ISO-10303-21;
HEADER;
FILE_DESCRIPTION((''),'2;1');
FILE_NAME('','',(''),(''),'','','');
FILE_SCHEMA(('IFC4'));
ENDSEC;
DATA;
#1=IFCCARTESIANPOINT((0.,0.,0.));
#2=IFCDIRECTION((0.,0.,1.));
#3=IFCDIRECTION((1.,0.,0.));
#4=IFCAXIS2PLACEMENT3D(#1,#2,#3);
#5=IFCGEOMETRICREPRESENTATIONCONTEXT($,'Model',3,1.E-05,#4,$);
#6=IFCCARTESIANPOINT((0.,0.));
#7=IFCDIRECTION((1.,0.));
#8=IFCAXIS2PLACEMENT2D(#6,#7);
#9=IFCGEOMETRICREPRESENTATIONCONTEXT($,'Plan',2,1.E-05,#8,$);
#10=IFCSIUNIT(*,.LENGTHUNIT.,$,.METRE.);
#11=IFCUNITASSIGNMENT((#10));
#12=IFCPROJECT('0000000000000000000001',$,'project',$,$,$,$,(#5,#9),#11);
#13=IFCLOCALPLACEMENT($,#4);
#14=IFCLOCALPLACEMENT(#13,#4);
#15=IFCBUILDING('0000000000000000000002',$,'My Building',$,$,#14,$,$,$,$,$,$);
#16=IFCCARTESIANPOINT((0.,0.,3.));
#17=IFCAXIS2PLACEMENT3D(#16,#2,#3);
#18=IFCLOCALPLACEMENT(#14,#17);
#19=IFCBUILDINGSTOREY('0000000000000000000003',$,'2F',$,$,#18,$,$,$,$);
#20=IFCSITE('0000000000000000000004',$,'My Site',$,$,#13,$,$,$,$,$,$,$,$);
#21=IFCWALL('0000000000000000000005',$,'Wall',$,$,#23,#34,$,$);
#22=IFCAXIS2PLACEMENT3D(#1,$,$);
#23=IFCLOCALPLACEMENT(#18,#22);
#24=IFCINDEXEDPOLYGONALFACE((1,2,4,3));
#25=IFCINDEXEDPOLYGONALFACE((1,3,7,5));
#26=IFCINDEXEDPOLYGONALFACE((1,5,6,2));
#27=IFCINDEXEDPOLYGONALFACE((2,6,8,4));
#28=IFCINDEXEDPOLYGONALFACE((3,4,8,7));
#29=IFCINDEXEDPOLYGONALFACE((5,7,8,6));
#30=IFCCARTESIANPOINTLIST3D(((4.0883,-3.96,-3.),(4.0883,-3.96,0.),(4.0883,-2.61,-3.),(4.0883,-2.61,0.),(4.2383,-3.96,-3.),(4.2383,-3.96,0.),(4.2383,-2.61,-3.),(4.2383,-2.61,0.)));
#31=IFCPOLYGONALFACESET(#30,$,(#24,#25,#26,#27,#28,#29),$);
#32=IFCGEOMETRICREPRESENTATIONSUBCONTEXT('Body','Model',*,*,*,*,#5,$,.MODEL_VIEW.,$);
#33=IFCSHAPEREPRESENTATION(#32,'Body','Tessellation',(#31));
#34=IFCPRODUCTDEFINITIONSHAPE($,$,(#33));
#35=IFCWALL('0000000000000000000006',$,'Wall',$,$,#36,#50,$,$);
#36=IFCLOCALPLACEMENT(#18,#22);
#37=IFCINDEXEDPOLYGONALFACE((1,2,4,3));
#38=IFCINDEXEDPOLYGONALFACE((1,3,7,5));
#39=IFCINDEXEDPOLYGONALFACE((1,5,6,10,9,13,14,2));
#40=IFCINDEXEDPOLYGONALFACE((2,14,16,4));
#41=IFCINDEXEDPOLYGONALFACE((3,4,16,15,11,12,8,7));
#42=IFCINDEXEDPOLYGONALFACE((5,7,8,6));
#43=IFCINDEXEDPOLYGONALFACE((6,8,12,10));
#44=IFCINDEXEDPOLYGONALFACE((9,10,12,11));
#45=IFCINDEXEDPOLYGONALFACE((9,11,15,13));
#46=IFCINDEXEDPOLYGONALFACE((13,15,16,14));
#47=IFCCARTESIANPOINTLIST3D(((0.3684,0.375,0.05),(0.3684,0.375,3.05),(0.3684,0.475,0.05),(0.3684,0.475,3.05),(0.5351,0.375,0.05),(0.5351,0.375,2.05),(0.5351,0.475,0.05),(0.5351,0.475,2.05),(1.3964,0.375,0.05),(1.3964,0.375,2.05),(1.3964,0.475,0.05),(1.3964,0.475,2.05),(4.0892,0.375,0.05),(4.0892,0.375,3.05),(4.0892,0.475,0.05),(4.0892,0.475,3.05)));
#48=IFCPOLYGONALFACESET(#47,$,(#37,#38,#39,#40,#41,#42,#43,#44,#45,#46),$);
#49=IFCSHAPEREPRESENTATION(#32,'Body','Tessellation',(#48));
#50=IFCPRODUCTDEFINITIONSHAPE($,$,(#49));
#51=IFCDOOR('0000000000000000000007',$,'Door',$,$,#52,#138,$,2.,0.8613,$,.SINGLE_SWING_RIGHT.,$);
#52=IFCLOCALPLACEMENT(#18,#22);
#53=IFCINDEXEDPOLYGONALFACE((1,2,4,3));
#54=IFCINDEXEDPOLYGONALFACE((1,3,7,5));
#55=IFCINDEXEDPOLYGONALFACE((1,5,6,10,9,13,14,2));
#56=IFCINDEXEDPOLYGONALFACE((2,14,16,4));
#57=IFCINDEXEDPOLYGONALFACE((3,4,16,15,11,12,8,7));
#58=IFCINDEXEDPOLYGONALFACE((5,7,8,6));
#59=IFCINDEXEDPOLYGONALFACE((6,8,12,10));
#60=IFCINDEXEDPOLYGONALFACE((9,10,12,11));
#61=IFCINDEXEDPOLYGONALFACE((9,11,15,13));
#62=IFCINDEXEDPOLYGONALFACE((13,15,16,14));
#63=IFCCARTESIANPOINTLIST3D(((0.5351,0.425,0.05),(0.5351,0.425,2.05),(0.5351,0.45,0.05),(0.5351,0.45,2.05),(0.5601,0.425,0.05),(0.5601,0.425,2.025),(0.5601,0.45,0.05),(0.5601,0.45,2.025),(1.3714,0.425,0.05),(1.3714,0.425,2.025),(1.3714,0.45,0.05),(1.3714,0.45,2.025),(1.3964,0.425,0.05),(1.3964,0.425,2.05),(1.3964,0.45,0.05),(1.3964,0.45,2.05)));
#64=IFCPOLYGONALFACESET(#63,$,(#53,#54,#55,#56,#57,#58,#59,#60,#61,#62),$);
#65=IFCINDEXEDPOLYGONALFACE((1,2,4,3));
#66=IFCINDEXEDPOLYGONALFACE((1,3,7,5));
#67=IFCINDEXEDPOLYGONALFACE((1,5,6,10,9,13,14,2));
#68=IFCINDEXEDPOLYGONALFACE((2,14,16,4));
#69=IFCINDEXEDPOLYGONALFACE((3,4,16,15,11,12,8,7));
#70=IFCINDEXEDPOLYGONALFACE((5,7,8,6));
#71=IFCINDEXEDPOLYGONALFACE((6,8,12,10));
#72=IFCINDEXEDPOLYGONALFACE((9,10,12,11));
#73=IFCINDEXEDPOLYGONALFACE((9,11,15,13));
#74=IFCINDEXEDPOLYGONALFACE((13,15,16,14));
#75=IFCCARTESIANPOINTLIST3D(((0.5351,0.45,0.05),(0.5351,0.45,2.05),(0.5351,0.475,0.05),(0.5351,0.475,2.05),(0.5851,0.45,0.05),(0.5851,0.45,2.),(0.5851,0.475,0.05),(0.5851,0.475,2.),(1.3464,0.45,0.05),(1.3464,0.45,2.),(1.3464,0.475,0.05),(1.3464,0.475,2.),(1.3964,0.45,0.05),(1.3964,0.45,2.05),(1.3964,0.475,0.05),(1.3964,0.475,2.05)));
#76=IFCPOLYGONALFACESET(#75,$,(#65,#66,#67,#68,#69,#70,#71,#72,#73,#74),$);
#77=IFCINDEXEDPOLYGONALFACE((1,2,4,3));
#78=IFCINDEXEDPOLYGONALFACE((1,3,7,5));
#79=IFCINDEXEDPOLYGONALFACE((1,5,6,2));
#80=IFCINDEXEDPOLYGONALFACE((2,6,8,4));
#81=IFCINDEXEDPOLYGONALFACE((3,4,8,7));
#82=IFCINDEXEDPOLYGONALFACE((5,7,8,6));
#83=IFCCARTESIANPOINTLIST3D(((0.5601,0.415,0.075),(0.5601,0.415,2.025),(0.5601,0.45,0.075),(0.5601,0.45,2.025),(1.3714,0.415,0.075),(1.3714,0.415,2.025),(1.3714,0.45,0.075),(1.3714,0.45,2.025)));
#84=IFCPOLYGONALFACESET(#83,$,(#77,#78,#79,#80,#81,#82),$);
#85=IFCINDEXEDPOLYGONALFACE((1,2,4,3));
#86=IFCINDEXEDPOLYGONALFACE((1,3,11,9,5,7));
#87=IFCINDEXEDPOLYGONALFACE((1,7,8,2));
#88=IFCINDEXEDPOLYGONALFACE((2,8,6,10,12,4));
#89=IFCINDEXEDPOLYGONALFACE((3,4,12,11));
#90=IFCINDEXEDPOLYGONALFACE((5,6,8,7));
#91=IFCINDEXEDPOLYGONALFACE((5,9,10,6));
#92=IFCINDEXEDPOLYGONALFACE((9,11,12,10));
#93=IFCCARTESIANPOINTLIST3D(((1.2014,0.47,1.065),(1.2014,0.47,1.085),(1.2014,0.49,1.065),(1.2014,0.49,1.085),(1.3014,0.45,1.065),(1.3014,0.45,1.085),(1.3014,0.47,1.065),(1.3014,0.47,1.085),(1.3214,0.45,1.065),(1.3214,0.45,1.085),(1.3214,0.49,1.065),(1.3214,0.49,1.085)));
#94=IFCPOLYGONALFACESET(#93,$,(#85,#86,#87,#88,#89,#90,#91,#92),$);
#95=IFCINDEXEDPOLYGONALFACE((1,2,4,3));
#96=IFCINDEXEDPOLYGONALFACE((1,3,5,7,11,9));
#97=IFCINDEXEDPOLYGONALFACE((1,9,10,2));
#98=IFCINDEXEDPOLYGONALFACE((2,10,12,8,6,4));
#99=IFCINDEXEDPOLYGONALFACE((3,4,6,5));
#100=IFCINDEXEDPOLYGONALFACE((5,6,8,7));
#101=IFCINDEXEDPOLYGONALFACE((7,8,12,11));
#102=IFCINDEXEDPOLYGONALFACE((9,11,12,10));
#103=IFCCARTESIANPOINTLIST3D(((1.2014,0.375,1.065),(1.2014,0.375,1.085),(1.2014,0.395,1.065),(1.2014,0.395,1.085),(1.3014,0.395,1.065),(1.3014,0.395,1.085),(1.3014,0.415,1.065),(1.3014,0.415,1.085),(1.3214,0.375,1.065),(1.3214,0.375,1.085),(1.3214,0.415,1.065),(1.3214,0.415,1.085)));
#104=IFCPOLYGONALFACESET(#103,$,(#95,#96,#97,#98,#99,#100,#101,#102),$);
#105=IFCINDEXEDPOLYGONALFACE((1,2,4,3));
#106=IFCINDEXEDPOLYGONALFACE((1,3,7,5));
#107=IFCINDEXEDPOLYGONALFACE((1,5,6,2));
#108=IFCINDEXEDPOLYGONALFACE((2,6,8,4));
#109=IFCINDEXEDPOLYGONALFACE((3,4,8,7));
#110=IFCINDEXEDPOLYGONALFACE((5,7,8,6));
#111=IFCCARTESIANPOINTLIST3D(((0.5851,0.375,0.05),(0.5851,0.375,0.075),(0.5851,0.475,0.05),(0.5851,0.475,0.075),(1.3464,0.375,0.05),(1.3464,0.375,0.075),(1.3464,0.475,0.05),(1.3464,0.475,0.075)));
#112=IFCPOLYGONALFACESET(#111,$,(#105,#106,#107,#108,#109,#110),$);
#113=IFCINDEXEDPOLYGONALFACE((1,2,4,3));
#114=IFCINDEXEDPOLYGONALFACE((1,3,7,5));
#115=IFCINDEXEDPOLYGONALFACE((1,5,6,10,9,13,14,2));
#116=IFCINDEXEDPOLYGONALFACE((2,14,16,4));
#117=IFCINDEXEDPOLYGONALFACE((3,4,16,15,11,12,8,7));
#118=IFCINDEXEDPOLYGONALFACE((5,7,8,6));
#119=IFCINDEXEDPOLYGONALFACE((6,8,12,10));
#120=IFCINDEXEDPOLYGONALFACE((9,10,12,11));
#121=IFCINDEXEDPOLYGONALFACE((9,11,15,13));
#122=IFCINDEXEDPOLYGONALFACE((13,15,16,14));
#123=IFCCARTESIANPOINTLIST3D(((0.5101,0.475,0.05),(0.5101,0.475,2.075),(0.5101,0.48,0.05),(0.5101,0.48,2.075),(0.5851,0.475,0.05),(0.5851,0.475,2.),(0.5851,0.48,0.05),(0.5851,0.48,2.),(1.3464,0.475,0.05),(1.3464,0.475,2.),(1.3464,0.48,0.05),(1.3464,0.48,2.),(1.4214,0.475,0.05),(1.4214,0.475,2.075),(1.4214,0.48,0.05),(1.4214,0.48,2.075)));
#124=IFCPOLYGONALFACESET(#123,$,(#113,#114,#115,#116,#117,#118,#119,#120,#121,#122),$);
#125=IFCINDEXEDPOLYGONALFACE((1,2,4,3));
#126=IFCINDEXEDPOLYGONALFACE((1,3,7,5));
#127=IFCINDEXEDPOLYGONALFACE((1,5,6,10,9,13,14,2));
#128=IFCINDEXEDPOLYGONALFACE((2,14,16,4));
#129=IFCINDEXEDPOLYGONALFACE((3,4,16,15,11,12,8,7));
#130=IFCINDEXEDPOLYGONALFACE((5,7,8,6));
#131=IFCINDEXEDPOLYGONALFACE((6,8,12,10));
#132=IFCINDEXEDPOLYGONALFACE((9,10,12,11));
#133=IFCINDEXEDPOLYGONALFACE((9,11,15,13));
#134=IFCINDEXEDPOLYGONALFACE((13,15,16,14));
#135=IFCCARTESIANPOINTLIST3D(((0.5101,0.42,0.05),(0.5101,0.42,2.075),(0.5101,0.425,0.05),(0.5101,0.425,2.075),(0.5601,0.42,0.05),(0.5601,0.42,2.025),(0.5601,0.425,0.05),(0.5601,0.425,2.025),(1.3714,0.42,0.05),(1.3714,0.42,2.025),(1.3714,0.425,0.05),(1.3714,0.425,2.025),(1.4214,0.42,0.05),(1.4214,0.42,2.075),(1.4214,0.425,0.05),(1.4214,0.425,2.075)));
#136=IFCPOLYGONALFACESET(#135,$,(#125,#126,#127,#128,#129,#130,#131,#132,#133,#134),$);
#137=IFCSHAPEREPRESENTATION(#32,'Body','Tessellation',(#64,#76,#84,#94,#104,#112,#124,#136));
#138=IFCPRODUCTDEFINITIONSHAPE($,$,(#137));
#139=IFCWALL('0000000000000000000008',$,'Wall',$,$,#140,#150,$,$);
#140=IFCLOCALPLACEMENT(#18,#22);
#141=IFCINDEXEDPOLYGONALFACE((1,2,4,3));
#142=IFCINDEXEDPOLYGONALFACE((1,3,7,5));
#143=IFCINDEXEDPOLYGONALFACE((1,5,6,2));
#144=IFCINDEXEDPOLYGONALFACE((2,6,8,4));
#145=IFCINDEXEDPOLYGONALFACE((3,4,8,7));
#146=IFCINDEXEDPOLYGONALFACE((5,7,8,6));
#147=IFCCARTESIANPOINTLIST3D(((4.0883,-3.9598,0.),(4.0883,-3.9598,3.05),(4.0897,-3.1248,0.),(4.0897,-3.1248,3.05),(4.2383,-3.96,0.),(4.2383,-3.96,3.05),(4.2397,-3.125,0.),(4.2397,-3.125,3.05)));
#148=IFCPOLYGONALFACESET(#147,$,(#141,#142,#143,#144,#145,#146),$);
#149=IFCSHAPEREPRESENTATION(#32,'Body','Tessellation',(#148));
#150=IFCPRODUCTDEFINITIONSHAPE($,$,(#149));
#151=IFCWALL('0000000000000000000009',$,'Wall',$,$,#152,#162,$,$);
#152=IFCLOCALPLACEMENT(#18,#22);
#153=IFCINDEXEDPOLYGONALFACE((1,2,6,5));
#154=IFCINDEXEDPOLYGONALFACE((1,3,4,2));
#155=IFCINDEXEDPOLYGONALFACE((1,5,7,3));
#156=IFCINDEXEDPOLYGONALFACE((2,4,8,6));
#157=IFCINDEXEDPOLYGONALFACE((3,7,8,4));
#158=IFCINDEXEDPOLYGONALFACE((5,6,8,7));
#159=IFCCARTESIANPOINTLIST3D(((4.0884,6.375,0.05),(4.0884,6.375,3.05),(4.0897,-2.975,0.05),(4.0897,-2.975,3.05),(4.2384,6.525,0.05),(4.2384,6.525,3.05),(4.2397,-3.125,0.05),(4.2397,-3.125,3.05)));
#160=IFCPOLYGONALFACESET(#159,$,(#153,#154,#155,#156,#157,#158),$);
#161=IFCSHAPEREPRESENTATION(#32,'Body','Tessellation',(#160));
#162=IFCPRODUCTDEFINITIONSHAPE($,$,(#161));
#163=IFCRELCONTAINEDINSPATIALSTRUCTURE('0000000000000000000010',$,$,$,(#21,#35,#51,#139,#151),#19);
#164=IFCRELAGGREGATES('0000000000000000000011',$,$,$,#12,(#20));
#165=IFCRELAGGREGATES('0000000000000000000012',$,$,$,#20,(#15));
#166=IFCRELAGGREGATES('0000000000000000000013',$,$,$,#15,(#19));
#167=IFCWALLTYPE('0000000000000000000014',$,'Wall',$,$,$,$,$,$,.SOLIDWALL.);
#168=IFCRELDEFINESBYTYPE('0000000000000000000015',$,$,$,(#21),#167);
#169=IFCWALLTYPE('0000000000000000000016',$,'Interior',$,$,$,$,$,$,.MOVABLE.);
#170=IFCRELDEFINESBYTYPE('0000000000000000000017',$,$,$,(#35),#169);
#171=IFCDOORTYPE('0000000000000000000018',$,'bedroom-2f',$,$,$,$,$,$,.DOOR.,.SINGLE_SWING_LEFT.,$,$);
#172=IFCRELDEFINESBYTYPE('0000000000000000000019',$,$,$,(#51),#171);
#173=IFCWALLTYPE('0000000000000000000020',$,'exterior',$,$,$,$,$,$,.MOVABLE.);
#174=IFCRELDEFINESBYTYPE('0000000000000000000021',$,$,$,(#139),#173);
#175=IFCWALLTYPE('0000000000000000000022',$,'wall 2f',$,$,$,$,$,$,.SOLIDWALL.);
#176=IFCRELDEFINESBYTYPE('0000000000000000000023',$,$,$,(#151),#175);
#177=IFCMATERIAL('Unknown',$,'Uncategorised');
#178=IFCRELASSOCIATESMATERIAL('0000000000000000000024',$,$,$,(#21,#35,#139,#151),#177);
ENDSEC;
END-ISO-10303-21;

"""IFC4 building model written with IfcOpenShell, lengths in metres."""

from ifc_helpers import new_model, entity, si_unit, frame, origin_with_axes, origin_2d_with_axis, place, context, subcontext, project, spatial, line, indexed_curve, outline, extrude, shape, source, transform, mapped, material, type_object, type_shapes, element, fill, save


model = new_model("IFC4")

# Units and contexts
model_context = context("Model", 3, precision=1e-05, world=origin_with_axes())
plan_context = context("Plan", 2, precision=1e-05, world=origin_2d_with_axis())
body_context_1 = subcontext(model_context, "Body", "Model", "MODEL_VIEW")
body_context_2 = subcontext(plan_context, "Body", "Plan", "PLAN_VIEW")
ifc_project = project(units=[si_unit("LENGTHUNIT", "METRE")], contexts=[model_context, plan_context])

# Site, building, storey
site_placement = place(None, origin_with_axes())
site = spatial("IfcSite", under=ifc_project, at=site_placement, Name="My Site")
building_placement = place(site_placement, origin_with_axes())
building = spatial("IfcBuilding", under=site, at=building_placement, Name="My Building")
storey_placement = place(building_placement, frame((0.0, 0.0, 3.0), z_axis=(0.0, 0.0, 1.0), x_axis=(1.0, 0.0, 0.0)))
storey = spatial("IfcBuildingStorey", under=building, at=storey_placement, Name="2F")

# Wall
ifc_material = material(Name="Unknown", Category="Uncategorised")
wall_type_1 = type_object("IfcWallType", Name="Wall", PredefinedType="SOLIDWALL")
wall_1_placement = place(storey_placement, frame((4.0883, -2.61, -3.0), z_axis=(0.0, 0.0, 1.0), x_axis=(0.0, -1.0, 0.0)))
element("IfcWall", 1, at=wall_1_placement, inside=storey, type_object=wall_type_1, material=ifc_material, Name="Wall", context=body_context_1, shape_type="SweptSolid", body=[
    extrude(outline(indexed_curve([(0.0, 0.0), (0.0, 0.15), (1.35, 0.15), (1.35, 0.0)], segments=[line(1, 2, 3, 4, 1)])), origin_with_axes(), (0.0, 0.0, 1.0), 3.0),
])

# Wall, opening, door
wall_type_2 = type_object("IfcWallType", Name="Interior", PredefinedType="MOVABLE")
wall_2_placement = place(storey_placement, frame((0.3684, 0.375, 0.05), z_axis=(0.0, 0.0, 1.0), x_axis=(1.0, 0.0, 0.0)))
wall_2 = element("IfcWall", 2, at=wall_2_placement, inside=storey, type_object=wall_type_2, material=ifc_material, Name="Wall", context=body_context_1, shape_type="SweptSolid", body=[
    extrude(outline(indexed_curve([(0.0, 0.0), (0.0, 0.1), (3.7209, 0.1), (3.7209, 0.0)], segments=[line(1, 2, 3, 4, 1)])), origin_with_axes(), (0.0, 0.0, 1.0), 3.0),
])
shared_shape_1 = source(origin_with_axes(), body_context_1, "Body", "SweptSolid", [
    extrude(outline(indexed_curve([(0.0, 0.0), (0.8613, 0.0), (0.8613, 2.0), (0.0, 2.0)], segments=[line(1, 2, 3, 4, 1)])), frame((0.0, -0.6, 0.0), z_axis=(0.0, -1.0, 0.0), x_axis=(1.0, 0.0, 0.0)), (0.0, 0.0, -1.0), 1.2),
])
opening_1_placement = place(wall_2_placement, frame((1.028, 0.1, 0.0), z_axis=(0.0, 0.0, 1.0), x_axis=(-1.0, 0.0, 0.0)))
opening_1 = element("IfcOpeningElement", 3, at=opening_1_placement, cuts=wall_2, PredefinedType="OPENING", context=body_context_1, shape_type="MappedRepresentation", body=[
    mapped(shared_shape_1, transform((0.0, 0.0, 0.0), x_axis=(1.0, 0.0, 0.0), y_axis=(0.0, 1.0, 0.0), z_axis=(0.0, 0.0, 1.0), scale=1.0)),
])
door_type_1 = type_object("IfcDoorType", Name="bedroom-2f", OperationType="SINGLE_SWING_LEFT", PredefinedType="DOOR")
shared_shape_2 = source(origin_with_axes(), body_context_1, "Body", "SweptSolid", [
    extrude(outline(indexed_curve([(0.0, 0.0), (0.0, 2.0), (0.8613, 2.0), (0.8613, 0.0), (0.8363, 0.0), (0.8363, 1.975), (0.025, 1.975), (0.025, 0.0)], segments=[line(1, 2, 3, 4, 5, 6, 7, 8, 1)])), frame((0.0, 0.025, 0.0), z_axis=(0.0, -1.0, 0.0), x_axis=(1.0, 0.0, 0.0)), (0.0, 0.0, -1.0), 0.025),
    extrude(outline(indexed_curve([(0.0, 0.0), (0.0, 2.0), (0.8613, 2.0), (0.8613, 0.0), (0.8113, 0.0), (0.8113, 1.95), (0.05, 1.95), (0.05, 0.0)], segments=[line(1, 2, 3, 4, 5, 6, 7, 8, 1)])), frame((0.0, 0.0, 0.0), z_axis=(0.0, -1.0, 0.0), x_axis=(1.0, 0.0, 0.0)), (0.0, 0.0, -1.0), 0.025),
    extrude(outline(indexed_curve([(0.0, 0.0), (0.8113, 0.0), (0.8113, 0.035), (0.0, 0.035)], segments=[line(1, 2, 3, 4, 1)])), frame((0.025, 0.025, 0.025), z_axis=(0.0, 0.0, 1.0), x_axis=(1.0, 0.0, 0.0)), (0.0, 0.0, 1.0), 1.95),
    extrude(outline(indexed_curve([(0.0, 0.0), (0.0, -0.04), (0.12, -0.04), (0.12, -0.02), (0.02, -0.02), (0.02, 0.0)], segments=[line(1, 2, 3, 4, 5, 6, 1)])), frame((0.075, 0.025, 1.015), z_axis=(0.0, 0.0, 1.0), x_axis=(1.0, 0.0, 0.0)), (0.0, 0.0, 1.0), 0.02),
    extrude(outline(indexed_curve([(0.0, 0.0), (0.0, 0.04), (0.12, 0.04), (0.12, 0.02), (0.02, 0.02), (0.02, 0.0)], segments=[line(1, 2, 3, 4, 5, 6, 1)])), frame((0.075, 0.06, 1.015), z_axis=(0.0, 0.0, 1.0), x_axis=(1.0, 0.0, 0.0)), (0.0, 0.0, 1.0), 0.02),
    extrude(outline(indexed_curve([(0.0, 0.0), (0.7613, 0.0), (0.7613, 0.1), (0.0, 0.1)], segments=[line(1, 2, 3, 4, 1)])), frame((0.05, 0.0, 0.0), z_axis=(0.0, 0.0, 1.0), x_axis=(1.0, 0.0, 0.0)), (0.0, 0.0, 1.0), 0.025),
    extrude(outline(indexed_curve([(0.0, 0.0), (0.0, 2.025), (0.9113, 2.025), (0.9113, 0.0), (0.8363, 0.0), (0.8363, 1.95), (0.075, 1.95), (0.075, 0.0)], segments=[line(1, 2, 3, 4, 5, 6, 7, 8, 1)])), frame((-0.025, -0.005, 0.0), z_axis=(0.0, -1.0, 0.0), x_axis=(1.0, 0.0, 0.0)), (0.0, 0.0, -1.0), 0.005),
    extrude(outline(indexed_curve([(0.0, 0.0), (0.0, 2.025), (0.9113, 2.025), (0.9113, 0.0), (0.8613, 0.0), (0.8613, 1.975), (0.05, 1.975), (0.05, 0.0)], segments=[line(1, 2, 3, 4, 5, 6, 7, 8, 1)])), frame((-0.025, 0.05, 0.0), z_axis=(0.0, -1.0, 0.0), x_axis=(1.0, 0.0, 0.0)), (0.0, 0.0, -1.0), 0.005),
])
shared_shape_3 = source(origin_with_axes(), body_context_2, "Body", "Curve2D", [
    entity("IfcIndexedPolyCurve", entity("IfcCartesianPointList2D", [[0.0, 0.0], [0.0, 0.05], [0.025, 0.05], [0.025, 0.025], [0.05, 0.025], [0.05, 0.0]]), [entity("IfcLineIndex", [1, 2, 3, 4, 5, 6, 1])]),
    entity("IfcIndexedPolyCurve", entity("IfcCartesianPointList2D", [[0.8613, 0.0], [0.8613, 0.05], [0.8363, 0.05], [0.8363, 0.025], [0.8113, 0.025], [0.8113, 0.0]]), [entity("IfcLineIndex", [1, 2, 3, 4, 5, 6, 1])]),
    entity("IfcTrimmedCurve", entity("IfcEllipse", entity("IfcAxis2Placement2D", entity("IfcCartesianPoint", [0.8013, 0.05]), entity("IfcDirection", [1.0, 0.0])), 0.7763, 0.8113), [entity("IfcCartesianPoint", [0.8013, 0.8613])], [entity("IfcCartesianPoint", [0.025, 0.05])], True, "CARTESIAN"),
    entity("IfcIndexedPolyCurve", entity("IfcCartesianPointList2D", [[0.8363, 0.05], [0.8013, 0.05], [0.8013, 0.8613], [0.8363, 0.8613]]), [entity("IfcLineIndex", [1, 2, 3, 4, 1])]),
])
type_shapes(door_type_1, [shared_shape_2, shared_shape_3])
door_1_placement = place(opening_1_placement, origin_with_axes())
door_1 = element("IfcDoor", 4, at=door_1_placement, inside=storey, type_object=door_type_1, Name="Door", OperationType="SINGLE_SWING_RIGHT", OverallHeight=2.0, OverallWidth=0.8613, shapes=[
    shape(body_context_1, "Body", "MappedRepresentation", [mapped(shared_shape_2, transform((0.0, 0.0, 0.0), x_axis=(1.0, 0.0, 0.0), y_axis=(0.0, 1.0, 0.0), z_axis=(0.0, 0.0, 1.0), scale=1.0))]),
    shape(body_context_2, "Body", "MappedRepresentation", [mapped(shared_shape_3, transform((0.0, 0.0, 0.0), x_axis=(1.0, 0.0, 0.0), y_axis=(0.0, 1.0, 0.0), z_axis=(0.0, 0.0, 1.0), scale=1.0))]),
])
fill(opening_1, door_1)

# Walls
wall_type_3 = type_object("IfcWallType", Name="exterior", PredefinedType="MOVABLE")
wall_3_placement = place(storey_placement, frame((4.2383, -3.96, 0.0), z_axis=(0.0, 0.0, 1.0), x_axis=(0.00165, 0.999999, 0.0)))
element("IfcWall", 5, at=wall_3_placement, inside=storey, type_object=wall_type_3, material=ifc_material, Name="Wall", context=body_context_1, shape_type="SweptSolid", body=[
    extrude(outline(indexed_curve([(0.0, 0.0), (0.0, 0.15), (0.835, 0.15), (0.835, 0.0)], segments=[line(1, 2, 3, 4, 1)])), origin_with_axes(), (0.0, 0.0, 1.0), 3.05),
])
wall_type_4 = type_object("IfcWallType", Name="wall 2f", PredefinedType="SOLIDWALL")
wall_4_placement = place(storey_placement, frame((4.2397, -3.125, 0.05), z_axis=(0.0, 0.0, 1.0), x_axis=(-0.000142, 1.0, 0.0)))
element("IfcWall", 6, at=wall_4_placement, inside=storey, type_object=wall_type_4, material=ifc_material, Name="Wall", context=body_context_1, shape_type="SweptSolid", body=[
    extrude(outline(indexed_curve([(0.0, 0.0), (0.15, 0.15), (9.5, 0.15), (9.65, 0.0)], segments=[line(1, 2, 3, 4, 1)])), origin_with_axes(), (0.0, 0.0, 1.0), 3.0),
])

save(model, "model.ifc")
